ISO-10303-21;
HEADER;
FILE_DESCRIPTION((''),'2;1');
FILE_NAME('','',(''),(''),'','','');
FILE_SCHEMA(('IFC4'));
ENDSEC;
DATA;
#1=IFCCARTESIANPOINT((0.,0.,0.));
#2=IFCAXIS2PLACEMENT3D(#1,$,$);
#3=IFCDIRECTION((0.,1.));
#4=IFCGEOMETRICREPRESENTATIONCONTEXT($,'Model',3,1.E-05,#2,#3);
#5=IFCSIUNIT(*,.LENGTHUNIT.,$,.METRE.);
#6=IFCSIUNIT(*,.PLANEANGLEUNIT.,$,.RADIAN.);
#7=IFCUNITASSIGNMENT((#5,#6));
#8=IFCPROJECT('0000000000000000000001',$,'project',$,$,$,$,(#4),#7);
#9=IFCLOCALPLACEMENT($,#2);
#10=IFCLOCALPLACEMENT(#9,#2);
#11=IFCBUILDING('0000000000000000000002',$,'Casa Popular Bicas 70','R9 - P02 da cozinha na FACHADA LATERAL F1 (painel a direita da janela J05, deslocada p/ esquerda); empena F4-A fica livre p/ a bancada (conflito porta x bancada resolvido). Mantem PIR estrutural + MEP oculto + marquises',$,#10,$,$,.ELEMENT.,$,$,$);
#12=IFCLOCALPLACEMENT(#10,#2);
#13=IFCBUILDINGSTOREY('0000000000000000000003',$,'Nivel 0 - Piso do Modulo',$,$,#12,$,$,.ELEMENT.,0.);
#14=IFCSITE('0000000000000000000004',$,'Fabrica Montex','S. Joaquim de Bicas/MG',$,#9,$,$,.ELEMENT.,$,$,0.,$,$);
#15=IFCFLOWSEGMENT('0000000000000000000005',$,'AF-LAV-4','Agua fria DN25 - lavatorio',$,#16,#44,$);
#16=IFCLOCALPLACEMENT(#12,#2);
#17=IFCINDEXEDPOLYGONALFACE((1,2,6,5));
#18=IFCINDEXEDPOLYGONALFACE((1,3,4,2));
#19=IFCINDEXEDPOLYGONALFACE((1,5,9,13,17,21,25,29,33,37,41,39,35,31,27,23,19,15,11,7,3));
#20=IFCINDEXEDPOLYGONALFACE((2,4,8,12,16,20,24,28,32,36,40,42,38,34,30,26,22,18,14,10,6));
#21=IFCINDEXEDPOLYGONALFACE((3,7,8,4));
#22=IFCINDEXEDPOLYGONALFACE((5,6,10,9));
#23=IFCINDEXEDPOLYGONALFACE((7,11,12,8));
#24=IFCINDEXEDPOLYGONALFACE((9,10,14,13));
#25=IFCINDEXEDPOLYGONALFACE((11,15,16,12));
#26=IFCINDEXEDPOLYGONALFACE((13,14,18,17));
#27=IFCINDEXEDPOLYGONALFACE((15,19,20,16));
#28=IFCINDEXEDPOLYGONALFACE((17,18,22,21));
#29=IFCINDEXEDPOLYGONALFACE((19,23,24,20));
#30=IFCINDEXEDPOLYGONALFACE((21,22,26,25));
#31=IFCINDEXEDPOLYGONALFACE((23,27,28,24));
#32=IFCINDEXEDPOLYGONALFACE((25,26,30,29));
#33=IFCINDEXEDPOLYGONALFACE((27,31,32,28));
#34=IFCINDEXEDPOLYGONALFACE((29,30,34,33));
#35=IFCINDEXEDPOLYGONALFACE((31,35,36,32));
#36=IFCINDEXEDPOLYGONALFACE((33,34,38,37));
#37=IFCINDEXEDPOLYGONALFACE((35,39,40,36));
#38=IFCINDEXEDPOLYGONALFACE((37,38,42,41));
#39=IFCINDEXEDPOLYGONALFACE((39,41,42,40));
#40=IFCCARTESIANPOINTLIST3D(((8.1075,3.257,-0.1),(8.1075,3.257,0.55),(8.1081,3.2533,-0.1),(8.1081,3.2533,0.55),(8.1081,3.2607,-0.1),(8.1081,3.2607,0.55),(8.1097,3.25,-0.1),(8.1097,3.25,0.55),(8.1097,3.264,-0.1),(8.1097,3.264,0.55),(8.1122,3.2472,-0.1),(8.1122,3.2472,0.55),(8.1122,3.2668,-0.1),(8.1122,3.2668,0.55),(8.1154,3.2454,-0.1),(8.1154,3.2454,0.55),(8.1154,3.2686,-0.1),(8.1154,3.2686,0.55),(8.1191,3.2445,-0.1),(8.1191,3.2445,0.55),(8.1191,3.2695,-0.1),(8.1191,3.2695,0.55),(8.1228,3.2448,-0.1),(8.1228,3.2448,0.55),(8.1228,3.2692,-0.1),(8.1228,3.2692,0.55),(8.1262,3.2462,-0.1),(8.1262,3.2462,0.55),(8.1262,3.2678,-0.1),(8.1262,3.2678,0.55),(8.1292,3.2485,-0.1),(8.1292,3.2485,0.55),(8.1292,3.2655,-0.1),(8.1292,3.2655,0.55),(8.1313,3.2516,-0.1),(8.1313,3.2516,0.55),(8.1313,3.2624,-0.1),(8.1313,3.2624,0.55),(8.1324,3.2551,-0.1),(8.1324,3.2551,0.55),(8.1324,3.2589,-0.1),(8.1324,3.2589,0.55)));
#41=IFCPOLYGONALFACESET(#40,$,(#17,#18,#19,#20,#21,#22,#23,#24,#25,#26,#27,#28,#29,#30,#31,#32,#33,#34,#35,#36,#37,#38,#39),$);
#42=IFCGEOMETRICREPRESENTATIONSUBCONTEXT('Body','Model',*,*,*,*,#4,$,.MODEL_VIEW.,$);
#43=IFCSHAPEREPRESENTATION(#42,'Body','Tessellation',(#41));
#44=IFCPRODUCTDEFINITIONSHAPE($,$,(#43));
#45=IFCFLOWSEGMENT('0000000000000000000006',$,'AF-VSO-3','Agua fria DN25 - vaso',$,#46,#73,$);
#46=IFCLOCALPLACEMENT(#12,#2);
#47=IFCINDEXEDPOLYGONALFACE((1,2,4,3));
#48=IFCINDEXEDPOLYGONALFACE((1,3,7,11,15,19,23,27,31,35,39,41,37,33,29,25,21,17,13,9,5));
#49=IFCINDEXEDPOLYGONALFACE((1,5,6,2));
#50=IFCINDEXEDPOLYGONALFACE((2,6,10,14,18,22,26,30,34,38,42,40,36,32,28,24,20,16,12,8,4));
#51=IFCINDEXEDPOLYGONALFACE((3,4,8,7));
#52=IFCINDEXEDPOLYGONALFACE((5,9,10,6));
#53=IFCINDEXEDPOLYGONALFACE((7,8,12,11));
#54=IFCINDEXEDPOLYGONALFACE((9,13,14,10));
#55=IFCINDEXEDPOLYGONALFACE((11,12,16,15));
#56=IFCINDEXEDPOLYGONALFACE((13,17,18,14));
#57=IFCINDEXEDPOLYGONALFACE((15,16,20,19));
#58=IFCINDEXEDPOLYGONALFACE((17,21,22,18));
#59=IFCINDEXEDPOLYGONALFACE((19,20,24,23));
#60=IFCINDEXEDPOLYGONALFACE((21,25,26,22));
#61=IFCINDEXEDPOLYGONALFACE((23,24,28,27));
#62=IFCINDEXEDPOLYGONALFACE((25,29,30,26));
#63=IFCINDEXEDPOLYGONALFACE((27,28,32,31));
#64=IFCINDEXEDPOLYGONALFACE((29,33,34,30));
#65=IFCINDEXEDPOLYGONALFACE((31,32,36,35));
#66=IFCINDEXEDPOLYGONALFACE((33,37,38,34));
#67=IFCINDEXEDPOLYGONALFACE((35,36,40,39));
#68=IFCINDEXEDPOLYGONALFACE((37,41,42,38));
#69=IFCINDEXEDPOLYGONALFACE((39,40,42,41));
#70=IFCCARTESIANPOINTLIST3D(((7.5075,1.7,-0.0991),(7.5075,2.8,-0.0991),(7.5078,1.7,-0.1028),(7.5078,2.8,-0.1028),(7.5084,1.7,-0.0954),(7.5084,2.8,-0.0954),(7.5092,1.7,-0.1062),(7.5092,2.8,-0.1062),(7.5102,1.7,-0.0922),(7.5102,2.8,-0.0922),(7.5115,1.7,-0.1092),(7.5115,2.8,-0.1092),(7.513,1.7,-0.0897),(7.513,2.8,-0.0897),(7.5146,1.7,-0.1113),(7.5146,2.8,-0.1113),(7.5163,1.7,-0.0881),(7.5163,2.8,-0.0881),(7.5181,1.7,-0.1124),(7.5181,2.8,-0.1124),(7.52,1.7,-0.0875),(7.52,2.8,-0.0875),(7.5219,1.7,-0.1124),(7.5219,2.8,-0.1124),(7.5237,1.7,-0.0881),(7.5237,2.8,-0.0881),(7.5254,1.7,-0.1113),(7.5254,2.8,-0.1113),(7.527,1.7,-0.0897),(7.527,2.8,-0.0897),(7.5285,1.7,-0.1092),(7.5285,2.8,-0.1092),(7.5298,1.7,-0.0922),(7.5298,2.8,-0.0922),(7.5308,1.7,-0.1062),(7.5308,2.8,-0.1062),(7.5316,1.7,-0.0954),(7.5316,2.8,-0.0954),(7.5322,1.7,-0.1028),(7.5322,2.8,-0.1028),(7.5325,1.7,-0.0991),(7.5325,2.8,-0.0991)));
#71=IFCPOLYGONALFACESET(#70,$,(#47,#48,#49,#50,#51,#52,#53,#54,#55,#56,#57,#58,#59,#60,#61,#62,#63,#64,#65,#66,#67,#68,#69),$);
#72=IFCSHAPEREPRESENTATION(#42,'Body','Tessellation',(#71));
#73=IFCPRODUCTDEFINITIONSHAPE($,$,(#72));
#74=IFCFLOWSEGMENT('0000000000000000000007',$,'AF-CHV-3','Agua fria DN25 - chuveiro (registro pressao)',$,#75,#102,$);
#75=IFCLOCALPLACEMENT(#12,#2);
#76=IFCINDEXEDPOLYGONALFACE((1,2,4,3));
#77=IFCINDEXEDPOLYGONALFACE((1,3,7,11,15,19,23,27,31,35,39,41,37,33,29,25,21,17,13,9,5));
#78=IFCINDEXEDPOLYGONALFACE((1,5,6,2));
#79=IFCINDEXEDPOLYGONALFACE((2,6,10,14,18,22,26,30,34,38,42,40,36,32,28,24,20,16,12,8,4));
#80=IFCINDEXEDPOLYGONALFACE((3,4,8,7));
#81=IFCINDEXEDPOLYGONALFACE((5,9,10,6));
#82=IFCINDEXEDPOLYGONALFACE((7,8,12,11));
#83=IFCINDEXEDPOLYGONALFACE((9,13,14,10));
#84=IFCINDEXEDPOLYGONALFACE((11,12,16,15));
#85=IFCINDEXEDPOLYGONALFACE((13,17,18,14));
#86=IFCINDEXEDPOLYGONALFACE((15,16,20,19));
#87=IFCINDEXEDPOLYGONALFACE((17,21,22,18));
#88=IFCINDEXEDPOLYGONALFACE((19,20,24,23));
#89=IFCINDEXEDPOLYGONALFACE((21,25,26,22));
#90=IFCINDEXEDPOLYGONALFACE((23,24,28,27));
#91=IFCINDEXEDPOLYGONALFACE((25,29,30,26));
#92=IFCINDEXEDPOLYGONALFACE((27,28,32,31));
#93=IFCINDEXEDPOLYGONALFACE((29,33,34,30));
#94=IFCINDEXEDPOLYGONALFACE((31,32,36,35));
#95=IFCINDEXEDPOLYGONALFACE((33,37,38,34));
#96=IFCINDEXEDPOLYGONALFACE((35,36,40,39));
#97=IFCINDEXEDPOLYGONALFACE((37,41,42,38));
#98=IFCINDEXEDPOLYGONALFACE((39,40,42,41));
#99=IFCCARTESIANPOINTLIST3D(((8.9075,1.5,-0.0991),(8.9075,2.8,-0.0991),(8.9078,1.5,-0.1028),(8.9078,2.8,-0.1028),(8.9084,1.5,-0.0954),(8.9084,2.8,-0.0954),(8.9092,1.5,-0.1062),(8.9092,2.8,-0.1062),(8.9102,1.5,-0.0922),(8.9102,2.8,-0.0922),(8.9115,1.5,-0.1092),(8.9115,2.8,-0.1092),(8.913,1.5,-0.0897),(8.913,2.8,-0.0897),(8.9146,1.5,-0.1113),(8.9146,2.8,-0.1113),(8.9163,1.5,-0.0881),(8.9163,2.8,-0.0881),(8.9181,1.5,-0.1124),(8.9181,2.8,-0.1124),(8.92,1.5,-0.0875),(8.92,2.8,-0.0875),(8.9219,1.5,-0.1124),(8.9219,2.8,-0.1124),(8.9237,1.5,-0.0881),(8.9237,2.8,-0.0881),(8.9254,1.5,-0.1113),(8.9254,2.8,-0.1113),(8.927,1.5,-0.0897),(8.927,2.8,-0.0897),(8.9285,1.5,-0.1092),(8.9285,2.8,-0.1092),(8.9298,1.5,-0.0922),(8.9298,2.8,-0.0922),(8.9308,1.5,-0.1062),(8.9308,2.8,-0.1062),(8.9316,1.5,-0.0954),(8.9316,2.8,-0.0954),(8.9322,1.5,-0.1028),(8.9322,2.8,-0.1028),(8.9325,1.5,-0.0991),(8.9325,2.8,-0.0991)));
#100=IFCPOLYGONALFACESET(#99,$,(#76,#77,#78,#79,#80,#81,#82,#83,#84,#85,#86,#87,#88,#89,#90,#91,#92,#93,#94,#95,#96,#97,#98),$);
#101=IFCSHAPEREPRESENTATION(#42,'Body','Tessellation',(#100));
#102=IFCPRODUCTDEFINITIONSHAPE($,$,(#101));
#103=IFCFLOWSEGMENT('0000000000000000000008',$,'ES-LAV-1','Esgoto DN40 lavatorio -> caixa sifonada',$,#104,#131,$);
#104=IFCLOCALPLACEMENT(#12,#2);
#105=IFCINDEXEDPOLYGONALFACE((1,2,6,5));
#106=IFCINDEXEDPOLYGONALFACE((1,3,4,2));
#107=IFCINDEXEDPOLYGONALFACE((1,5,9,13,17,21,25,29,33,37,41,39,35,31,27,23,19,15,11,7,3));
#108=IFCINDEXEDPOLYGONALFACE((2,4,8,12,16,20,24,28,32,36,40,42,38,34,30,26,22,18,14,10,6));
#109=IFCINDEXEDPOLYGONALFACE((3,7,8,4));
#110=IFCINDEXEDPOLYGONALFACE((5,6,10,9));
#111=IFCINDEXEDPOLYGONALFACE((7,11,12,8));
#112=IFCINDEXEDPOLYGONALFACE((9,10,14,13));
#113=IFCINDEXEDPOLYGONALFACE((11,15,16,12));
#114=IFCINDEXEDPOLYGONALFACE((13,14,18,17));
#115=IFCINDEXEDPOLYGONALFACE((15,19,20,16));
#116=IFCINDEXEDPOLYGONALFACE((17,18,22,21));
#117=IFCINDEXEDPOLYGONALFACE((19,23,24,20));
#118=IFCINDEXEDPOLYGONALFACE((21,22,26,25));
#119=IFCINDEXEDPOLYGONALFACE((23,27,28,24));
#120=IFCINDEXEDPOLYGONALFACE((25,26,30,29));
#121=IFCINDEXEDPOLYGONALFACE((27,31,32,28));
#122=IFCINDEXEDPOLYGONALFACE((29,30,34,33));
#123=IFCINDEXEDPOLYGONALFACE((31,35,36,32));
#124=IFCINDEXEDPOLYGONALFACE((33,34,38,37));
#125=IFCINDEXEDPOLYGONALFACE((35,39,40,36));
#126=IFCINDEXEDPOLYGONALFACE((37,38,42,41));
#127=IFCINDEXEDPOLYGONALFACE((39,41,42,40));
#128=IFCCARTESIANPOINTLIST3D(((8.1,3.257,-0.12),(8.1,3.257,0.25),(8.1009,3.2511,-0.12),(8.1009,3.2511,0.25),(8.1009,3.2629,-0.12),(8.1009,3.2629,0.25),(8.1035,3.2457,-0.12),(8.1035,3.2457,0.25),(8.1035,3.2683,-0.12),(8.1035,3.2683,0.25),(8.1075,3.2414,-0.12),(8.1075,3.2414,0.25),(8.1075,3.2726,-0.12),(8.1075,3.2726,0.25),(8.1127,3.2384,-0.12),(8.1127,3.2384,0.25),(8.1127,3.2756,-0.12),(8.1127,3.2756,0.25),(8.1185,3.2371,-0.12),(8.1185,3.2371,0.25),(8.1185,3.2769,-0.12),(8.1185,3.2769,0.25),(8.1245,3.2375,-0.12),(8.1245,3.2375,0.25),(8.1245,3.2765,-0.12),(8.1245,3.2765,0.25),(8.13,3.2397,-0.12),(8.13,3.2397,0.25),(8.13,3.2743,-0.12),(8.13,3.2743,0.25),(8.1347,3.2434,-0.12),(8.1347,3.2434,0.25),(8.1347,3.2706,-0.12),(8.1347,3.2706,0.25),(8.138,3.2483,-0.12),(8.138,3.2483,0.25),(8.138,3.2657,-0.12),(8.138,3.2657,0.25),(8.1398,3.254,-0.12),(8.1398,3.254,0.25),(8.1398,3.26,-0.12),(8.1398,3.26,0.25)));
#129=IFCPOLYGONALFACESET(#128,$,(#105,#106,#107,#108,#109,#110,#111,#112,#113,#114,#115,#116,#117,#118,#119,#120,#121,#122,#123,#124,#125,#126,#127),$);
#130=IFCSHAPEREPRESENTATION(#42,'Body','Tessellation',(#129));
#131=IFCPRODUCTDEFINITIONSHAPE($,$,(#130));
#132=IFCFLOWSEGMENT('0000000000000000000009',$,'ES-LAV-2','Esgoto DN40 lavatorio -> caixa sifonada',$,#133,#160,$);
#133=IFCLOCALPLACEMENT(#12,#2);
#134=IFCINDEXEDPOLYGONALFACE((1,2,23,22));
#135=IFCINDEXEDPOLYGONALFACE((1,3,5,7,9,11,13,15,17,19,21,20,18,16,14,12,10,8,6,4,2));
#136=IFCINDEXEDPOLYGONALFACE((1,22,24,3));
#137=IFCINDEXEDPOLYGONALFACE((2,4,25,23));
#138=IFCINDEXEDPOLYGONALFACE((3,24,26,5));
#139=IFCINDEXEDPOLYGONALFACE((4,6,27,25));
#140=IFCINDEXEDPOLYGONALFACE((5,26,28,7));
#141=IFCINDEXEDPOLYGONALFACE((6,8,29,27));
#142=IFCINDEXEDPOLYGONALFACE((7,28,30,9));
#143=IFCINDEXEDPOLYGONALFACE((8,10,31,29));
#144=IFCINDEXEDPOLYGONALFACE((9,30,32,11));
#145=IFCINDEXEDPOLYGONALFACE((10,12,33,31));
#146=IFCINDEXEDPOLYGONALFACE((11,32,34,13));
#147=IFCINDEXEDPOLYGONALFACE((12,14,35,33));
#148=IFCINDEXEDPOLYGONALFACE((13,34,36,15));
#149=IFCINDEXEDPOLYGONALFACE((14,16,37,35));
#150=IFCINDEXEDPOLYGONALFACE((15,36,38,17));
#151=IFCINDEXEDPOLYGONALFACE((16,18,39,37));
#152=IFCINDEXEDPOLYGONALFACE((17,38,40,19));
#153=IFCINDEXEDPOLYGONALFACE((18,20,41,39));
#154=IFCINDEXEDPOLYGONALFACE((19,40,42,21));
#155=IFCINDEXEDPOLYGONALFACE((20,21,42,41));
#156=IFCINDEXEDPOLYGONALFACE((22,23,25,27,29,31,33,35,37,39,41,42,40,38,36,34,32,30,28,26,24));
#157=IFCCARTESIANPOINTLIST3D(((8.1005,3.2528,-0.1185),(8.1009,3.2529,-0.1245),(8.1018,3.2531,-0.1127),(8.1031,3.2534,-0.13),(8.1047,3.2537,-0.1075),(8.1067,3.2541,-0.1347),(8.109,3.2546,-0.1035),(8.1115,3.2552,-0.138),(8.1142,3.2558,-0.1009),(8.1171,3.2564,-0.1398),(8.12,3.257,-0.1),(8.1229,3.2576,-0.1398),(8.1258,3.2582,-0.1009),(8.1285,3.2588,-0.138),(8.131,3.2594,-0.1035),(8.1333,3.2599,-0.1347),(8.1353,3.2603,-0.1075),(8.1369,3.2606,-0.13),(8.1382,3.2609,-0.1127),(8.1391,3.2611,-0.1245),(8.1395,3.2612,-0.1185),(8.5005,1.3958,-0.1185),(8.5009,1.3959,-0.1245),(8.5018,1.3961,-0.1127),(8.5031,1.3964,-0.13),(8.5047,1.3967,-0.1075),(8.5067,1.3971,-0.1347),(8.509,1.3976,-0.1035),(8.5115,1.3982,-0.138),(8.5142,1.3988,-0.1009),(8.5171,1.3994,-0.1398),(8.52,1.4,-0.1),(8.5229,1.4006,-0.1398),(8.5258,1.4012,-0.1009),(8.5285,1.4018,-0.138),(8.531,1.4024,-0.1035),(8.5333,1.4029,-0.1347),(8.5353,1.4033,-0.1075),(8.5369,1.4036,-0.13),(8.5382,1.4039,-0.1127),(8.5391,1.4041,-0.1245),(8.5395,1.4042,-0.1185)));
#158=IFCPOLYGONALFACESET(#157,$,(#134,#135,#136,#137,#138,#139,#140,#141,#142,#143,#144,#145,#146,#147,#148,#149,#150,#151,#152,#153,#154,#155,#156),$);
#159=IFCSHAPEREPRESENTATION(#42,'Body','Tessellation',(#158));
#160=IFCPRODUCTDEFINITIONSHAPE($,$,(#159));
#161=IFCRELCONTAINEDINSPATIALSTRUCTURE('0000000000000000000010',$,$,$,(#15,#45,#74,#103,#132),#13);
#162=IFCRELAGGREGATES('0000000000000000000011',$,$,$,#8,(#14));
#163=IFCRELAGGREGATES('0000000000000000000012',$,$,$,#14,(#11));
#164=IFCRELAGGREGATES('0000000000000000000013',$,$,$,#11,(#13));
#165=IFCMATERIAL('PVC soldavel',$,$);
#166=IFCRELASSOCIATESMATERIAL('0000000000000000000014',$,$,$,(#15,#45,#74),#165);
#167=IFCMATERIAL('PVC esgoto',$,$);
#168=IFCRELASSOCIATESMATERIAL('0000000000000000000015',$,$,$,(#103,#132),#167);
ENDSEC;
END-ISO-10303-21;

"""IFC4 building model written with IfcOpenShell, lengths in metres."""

from ifc_helpers import new_model, si_unit, direction, frame, origin, origin_2d, place, context, subcontext, project, spatial, circle, extrude, material, element, save


model = new_model("IFC4")

# Units and contexts
model_context = context("Model", 3, precision=1e-05, world=origin(), true_north=direction((0.0, 1.0)))
body_context = subcontext(model_context, "Body", "Model", "MODEL_VIEW")
ifc_project = project(units=[si_unit("LENGTHUNIT", "METRE"), si_unit("PLANEANGLEUNIT", "RADIAN")], contexts=[model_context])

# Site, building, storey
site_placement = place(None, origin())
site = spatial("IfcSite", under=ifc_project, at=site_placement, Name="Fabrica Montex", Description="S. Joaquim de Bicas/MG", CompositionType="ELEMENT", RefElevation=0.0)
building_placement = place(site_placement, origin())
building = spatial("IfcBuilding", under=site, at=building_placement, Name="Casa Popular Bicas 70", Description="R9 - P02 da cozinha na FACHADA LATERAL F1 (painel a direita da janela J05, deslocada p/ esquerda); empena F4-A fica livre p/ a bancada (conflito porta x bancada resolvido). Mantem PIR estrutural + MEP oculto + marquises", CompositionType="ELEMENT")
storey_placement = place(building_placement, origin())
storey = spatial("IfcBuildingStorey", under=building, at=storey_placement, Name="Nivel 0 - Piso do Modulo", CompositionType="ELEMENT", Elevation=0.0)

# Flow segments
ifc_material_1 = material(Name="PVC soldavel")
flow_segment_1_placement = place(None, frame((8.12, 3.257, -0.1), z_axis=(0.0, 0.0, 1.0), x_axis=(-1.0, 0.0, 0.0)))
element("IfcFlowSegment", 1, at=flow_segment_1_placement, inside=storey, material=ifc_material_1, Name="AF-LAV-4", Description="Agua fria DN25 - lavatorio", context=body_context, shape_type="SweptSolid", body=[
    extrude(circle(Radius=0.0125, at=origin_2d()), origin(), (0.0, 0.0, 1.0), 0.65),
])
flow_segment_2_placement = place(None, frame((7.52, 2.8, -0.1), z_axis=(0.0, -1.0, 0.0), x_axis=(0.0, 0.0, 1.0)))
element("IfcFlowSegment", 2, at=flow_segment_2_placement, inside=storey, material=ifc_material_1, Name="AF-VSO-3", Description="Agua fria DN25 - vaso", context=body_context, shape_type="SweptSolid", body=[
    extrude(circle(Radius=0.0125, at=origin_2d()), origin(), (0.0, 0.0, 1.0), 1.1),
])
flow_segment_3_placement = place(None, frame((8.92, 2.8, -0.1), z_axis=(0.0, -1.0, 0.0), x_axis=(0.0, 0.0, 1.0)))
element("IfcFlowSegment", 3, at=flow_segment_3_placement, inside=storey, material=ifc_material_1, Name="AF-CHV-3", Description="Agua fria DN25 - chuveiro (registro pressao)", context=body_context, shape_type="SweptSolid", body=[
    extrude(circle(Radius=0.0125, at=origin_2d()), origin(), (0.0, 0.0, 1.0), 1.3),
])
ifc_material_2 = material(Name="PVC esgoto")
flow_segment_4_placement = place(None, frame((8.12, 3.257, 0.25), z_axis=(0.0, 0.0, -1.0), x_axis=(-1.0, 0.0, 0.0)))
element("IfcFlowSegment", 4, at=flow_segment_4_placement, inside=storey, material=ifc_material_2, Name="ES-LAV-1", Description="Esgoto DN40 lavatorio -> caixa sifonada", context=body_context, shape_type="SweptSolid", body=[
    extrude(circle(Radius=0.02, at=origin_2d()), origin(), (0.0, 0.0, 1.0), 0.37),
])
flow_segment_5_placement = place(None, frame((8.12, 3.257, -0.12), z_axis=(0.210572, -0.977578, 0.0), x_axis=(0.0, 0.0, 1.0)))
element("IfcFlowSegment", 5, at=flow_segment_5_placement, inside=storey, material=ifc_material_2, Name="ES-LAV-2", Description="Esgoto DN40 lavatorio -> caixa sifonada", context=body_context, shape_type="SweptSolid", body=[
    extrude(circle(Radius=0.02, at=origin_2d()), origin(), (0.0, 0.0, 1.0), 1.8996),
])

save(model, "model.ifc")
